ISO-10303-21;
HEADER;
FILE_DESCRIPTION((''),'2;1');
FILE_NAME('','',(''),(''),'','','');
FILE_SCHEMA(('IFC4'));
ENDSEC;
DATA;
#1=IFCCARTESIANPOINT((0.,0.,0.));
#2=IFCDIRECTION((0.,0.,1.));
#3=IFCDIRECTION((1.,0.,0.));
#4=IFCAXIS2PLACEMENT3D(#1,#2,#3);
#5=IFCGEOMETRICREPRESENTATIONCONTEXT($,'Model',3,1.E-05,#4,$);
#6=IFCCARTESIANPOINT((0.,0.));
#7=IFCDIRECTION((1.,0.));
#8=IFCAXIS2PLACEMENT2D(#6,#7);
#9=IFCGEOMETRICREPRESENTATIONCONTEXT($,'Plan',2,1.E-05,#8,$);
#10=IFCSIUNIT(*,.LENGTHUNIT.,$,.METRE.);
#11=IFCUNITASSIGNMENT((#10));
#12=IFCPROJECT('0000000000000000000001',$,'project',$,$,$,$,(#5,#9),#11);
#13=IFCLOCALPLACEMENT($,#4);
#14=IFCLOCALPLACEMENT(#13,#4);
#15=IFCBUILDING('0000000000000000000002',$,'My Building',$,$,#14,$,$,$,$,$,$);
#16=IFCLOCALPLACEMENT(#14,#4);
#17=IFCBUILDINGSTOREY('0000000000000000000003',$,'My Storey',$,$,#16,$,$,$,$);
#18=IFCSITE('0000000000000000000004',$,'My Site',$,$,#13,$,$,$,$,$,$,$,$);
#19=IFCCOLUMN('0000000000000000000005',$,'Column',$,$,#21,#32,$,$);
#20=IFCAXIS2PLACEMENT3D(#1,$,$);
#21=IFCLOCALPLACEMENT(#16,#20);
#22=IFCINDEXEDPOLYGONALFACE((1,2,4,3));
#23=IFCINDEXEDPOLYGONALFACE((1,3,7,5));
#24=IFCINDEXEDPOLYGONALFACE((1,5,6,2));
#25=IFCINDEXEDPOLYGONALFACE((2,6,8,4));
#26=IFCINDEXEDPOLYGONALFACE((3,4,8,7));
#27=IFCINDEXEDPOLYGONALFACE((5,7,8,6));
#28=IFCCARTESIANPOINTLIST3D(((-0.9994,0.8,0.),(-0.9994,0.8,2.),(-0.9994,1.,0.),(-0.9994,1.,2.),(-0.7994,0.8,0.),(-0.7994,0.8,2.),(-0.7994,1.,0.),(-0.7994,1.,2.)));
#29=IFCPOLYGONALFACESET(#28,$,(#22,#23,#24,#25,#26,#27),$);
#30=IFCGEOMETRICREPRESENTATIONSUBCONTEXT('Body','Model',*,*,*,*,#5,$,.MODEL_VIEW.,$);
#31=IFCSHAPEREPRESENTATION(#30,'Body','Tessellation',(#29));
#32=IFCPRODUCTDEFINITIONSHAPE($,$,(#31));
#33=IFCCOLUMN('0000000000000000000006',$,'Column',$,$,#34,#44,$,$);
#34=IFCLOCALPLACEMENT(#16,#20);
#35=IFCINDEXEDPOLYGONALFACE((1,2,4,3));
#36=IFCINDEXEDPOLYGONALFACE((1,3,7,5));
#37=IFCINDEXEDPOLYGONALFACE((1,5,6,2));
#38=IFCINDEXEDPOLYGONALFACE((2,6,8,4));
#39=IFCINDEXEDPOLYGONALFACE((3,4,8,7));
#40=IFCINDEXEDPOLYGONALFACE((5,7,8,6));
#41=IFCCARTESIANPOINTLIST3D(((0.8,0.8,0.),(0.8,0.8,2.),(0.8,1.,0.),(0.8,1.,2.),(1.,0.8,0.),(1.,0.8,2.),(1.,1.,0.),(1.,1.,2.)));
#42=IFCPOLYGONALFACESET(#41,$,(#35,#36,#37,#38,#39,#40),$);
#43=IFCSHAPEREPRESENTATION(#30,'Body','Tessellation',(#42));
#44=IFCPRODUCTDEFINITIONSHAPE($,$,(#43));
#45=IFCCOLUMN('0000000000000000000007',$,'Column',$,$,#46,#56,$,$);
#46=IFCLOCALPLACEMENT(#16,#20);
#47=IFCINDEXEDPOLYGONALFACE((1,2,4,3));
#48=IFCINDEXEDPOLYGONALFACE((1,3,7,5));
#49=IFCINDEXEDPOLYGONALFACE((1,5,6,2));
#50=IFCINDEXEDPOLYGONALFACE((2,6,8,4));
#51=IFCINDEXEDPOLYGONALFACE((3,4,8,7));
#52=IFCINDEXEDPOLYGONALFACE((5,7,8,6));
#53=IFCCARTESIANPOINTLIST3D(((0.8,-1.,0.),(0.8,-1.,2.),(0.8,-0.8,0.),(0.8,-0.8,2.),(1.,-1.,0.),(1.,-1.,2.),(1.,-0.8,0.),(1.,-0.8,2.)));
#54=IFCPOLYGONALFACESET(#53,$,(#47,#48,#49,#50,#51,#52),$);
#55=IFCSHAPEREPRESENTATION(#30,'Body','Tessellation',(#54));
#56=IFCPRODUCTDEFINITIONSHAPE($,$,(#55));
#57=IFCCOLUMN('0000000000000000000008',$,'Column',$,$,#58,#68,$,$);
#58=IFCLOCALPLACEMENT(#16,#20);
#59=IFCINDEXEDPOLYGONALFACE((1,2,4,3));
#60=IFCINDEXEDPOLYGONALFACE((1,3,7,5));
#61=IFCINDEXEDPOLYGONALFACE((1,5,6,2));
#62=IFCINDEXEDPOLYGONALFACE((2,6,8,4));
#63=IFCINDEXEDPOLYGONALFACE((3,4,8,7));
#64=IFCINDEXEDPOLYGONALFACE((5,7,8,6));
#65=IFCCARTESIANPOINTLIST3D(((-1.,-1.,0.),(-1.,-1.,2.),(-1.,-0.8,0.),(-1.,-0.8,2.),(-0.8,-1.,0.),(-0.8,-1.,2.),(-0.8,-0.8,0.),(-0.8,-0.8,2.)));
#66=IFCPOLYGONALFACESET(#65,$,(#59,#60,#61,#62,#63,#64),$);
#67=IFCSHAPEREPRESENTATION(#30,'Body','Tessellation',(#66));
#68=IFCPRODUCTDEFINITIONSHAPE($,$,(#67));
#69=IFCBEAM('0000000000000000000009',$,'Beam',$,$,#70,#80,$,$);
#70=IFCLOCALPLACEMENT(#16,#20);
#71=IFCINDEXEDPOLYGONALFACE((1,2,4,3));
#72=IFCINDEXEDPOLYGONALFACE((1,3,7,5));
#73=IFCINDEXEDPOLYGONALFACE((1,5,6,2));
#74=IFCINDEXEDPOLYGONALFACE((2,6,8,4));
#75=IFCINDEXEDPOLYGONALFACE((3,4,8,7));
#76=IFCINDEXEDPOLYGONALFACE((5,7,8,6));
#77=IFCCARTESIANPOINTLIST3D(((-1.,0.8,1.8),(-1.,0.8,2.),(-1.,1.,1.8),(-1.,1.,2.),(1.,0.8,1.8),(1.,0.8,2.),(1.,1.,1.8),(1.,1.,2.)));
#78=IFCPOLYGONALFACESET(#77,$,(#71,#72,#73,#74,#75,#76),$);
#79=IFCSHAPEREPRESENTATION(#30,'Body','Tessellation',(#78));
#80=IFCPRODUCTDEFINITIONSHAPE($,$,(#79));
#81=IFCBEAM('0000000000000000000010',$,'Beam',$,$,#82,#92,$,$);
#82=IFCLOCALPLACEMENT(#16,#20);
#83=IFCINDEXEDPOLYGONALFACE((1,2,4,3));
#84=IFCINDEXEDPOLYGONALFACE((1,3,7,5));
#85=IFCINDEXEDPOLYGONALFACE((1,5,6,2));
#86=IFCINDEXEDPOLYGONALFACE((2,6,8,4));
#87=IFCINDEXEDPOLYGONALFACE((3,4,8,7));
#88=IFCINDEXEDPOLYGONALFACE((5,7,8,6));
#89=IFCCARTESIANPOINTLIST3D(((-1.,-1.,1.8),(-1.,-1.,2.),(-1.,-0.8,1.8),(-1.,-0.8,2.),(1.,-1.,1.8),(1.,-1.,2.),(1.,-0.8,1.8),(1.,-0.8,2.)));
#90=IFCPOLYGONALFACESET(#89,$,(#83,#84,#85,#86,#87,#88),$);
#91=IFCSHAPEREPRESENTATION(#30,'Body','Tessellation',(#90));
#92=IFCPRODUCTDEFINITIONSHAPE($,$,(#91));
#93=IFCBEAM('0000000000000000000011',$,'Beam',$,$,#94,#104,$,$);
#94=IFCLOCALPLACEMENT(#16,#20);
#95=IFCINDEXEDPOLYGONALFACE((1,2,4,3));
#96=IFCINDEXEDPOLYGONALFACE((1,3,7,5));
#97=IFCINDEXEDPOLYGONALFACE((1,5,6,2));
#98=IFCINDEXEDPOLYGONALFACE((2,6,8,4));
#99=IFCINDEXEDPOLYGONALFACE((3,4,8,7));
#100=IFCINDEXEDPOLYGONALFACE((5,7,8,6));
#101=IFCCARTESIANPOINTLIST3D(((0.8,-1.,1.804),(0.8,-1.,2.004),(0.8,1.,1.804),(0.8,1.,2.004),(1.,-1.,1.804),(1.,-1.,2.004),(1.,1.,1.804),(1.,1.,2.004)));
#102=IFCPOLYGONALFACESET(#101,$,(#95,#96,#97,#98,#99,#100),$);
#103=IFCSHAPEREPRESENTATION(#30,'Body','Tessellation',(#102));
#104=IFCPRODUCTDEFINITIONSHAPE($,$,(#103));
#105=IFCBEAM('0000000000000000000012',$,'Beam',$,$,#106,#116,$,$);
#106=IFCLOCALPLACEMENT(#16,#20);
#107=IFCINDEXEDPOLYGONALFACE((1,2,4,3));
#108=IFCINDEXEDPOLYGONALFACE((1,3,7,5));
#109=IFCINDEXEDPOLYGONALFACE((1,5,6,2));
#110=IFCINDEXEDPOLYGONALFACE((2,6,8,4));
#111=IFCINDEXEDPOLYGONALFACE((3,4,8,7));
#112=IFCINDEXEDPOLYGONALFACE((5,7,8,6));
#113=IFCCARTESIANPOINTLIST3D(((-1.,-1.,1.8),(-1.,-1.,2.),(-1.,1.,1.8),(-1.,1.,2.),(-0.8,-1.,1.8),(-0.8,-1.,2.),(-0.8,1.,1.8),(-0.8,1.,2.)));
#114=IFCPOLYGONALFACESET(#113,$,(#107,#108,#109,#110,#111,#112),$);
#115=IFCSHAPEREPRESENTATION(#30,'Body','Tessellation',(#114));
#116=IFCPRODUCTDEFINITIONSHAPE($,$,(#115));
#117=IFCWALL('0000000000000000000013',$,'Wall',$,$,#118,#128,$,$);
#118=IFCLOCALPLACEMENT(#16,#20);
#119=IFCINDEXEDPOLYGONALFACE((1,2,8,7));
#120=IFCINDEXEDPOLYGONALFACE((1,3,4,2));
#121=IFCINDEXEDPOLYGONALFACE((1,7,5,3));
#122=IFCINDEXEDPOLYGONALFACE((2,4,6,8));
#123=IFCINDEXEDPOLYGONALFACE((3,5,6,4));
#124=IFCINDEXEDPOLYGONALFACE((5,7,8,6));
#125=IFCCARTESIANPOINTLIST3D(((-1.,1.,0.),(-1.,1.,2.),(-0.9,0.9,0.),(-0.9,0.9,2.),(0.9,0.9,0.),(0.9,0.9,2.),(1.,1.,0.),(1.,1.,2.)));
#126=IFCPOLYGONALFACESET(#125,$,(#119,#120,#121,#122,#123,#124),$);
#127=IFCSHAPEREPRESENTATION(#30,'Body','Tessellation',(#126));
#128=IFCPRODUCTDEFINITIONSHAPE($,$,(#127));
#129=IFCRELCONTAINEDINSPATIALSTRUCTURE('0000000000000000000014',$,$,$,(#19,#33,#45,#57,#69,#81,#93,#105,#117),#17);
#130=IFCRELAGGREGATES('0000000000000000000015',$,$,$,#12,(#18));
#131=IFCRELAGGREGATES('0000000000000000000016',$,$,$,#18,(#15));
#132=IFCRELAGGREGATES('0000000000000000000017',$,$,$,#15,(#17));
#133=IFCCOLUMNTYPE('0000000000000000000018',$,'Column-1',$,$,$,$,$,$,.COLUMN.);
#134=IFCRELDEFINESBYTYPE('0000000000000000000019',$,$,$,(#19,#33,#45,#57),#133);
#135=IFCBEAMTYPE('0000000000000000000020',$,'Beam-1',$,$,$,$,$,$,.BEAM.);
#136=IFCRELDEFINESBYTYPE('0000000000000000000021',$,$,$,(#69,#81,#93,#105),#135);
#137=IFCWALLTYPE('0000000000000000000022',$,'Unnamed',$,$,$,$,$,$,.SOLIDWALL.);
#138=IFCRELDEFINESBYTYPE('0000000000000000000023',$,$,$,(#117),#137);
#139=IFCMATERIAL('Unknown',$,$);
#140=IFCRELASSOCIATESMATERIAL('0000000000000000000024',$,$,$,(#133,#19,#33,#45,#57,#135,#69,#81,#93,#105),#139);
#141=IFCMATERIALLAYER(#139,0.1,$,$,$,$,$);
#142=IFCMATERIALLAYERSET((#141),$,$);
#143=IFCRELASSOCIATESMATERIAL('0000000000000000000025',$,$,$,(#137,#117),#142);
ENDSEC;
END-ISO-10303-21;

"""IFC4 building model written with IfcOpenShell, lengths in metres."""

from ifc_helpers import new_model, si_unit, frame, origin_with_axes, origin_2d_with_axis, place, context, subcontext, project, spatial, line, indexed_curve, rectangle, outline, extrude, material, layer, layer_set, layer_usage, material_profile, profile_set, profile_usage, type_object, element, save


model = new_model("IFC4")

# Units and contexts
model_context = context("Model", 3, precision=1e-05, world=origin_with_axes())
plan_context = context("Plan", 2, precision=1e-05, world=origin_2d_with_axis())
body_context_1 = subcontext(model_context, "Body", "Model", "MODEL_VIEW")
ifc_project = project(units=[si_unit("LENGTHUNIT", "METRE")], contexts=[model_context, plan_context])

# Site, building, storey
site_placement = place(None, origin_with_axes())
site = spatial("IfcSite", under=ifc_project, at=site_placement, Name="My Site")
building_placement = place(site_placement, origin_with_axes())
building = spatial("IfcBuilding", under=site, at=building_placement, Name="My Building")
storey_placement = place(building_placement, origin_with_axes())
storey = spatial("IfcBuildingStorey", under=building, at=storey_placement, Name="My Storey")

# Columns
ifc_material = material(Name="Unknown")
ifc_material_profile_1 = material_profile(ifc_material, rectangle(XDim=0.2, YDim=0.2))
ifc_profile_set_1 = profile_set([ifc_material_profile_1])
ifc_profile_usage_1 = profile_usage(ifc_profile_set_1, cardinal=4)
column_type = type_object("IfcColumnType", Name="Column-1", PredefinedType="COLUMN", material=ifc_profile_set_1)
column_1_placement = place(storey_placement, frame((-0.7994, 0.9, 0.0), z_axis=(0.0, 0.0, 1.0), x_axis=(1.0, 0.0, 0.0)))
element("IfcColumn", 1, at=column_1_placement, inside=storey, type_object=column_type, material=ifc_profile_usage_1, Name="Column", context=body_context_1, shape_type="SweptSolid", body=[
    extrude(rectangle(XDim=0.2, YDim=0.2), frame((-0.1, 0.0, 0.0), z_axis=(0.0, 0.0, 1.0), x_axis=(1.0, 0.0, 0.0)), (0.0, 0.0, 1.0), 2.0),
])
ifc_profile_usage_2 = profile_usage(ifc_profile_set_1, cardinal=4)
column_2_placement = place(storey_placement, frame((1.0, 0.9, 0.0), z_axis=(0.0, 0.0, 1.0), x_axis=(1.0, 0.0, 0.0)))
element("IfcColumn", 2, at=column_2_placement, inside=storey, type_object=column_type, material=ifc_profile_usage_2, Name="Column", context=body_context_1, shape_type="SweptSolid", body=[
    extrude(rectangle(XDim=0.2, YDim=0.2), frame((-0.1, 0.0, 0.0), z_axis=(0.0, 0.0, 1.0), x_axis=(1.0, 0.0, 0.0)), (0.0, 0.0, 1.0), 2.0),
])
ifc_profile_usage_3 = profile_usage(ifc_profile_set_1, cardinal=4)
column_3_placement = place(storey_placement, frame((1.0, -0.9, 0.0), z_axis=(0.0, 0.0, 1.0), x_axis=(1.0, 0.0, 0.0)))
element("IfcColumn", 3, at=column_3_placement, inside=storey, type_object=column_type, material=ifc_profile_usage_3, Name="Column", context=body_context_1, shape_type="SweptSolid", body=[
    extrude(rectangle(XDim=0.2, YDim=0.2), frame((-0.1, 0.0, 0.0), z_axis=(0.0, 0.0, 1.0), x_axis=(1.0, 0.0, 0.0)), (0.0, 0.0, 1.0), 2.0),
])
ifc_profile_usage_4 = profile_usage(ifc_profile_set_1, cardinal=4)
column_4_placement = place(storey_placement, frame((-0.8, -0.9, 0.0), z_axis=(0.0, 0.0, 1.0), x_axis=(1.0, 0.0, 0.0)))
element("IfcColumn", 4, at=column_4_placement, inside=storey, type_object=column_type, material=ifc_profile_usage_4, Name="Column", context=body_context_1, shape_type="SweptSolid", body=[
    extrude(rectangle(XDim=0.2, YDim=0.2), frame((-0.1, 0.0, 0.0), z_axis=(0.0, 0.0, 1.0), x_axis=(1.0, 0.0, 0.0)), (0.0, 0.0, 1.0), 2.0),
])

# Beams
ifc_material_profile_2 = material_profile(ifc_material, rectangle(XDim=0.2, YDim=0.2))
ifc_profile_set_2 = profile_set([ifc_material_profile_2])
ifc_profile_usage_5 = profile_usage(ifc_profile_set_2, cardinal=4)
beam_type = type_object("IfcBeamType", Name="Beam-1", PredefinedType="BEAM", material=ifc_profile_set_2)
beam_1_placement = place(storey_placement, frame((1.0, 0.8, 1.9), z_axis=(-1.0, 0.0, 0.0), x_axis=(0.0, -1.0, 0.0)))
element("IfcBeam", 5, at=beam_1_placement, inside=storey, type_object=beam_type, material=ifc_profile_usage_5, Name="Beam", context=body_context_1, shape_type="SweptSolid", body=[
    extrude(rectangle(XDim=0.2, YDim=0.2), frame((-0.1, 0.0, 0.0), z_axis=(0.0, 0.0, 1.0), x_axis=(1.0, 0.0, 0.0)), (0.0, 0.0, 1.0), 2.0),
])
ifc_profile_usage_6 = profile_usage(ifc_profile_set_2, cardinal=4)
beam_2_placement = place(storey_placement, frame((1.0, -1.0, 1.9), z_axis=(-1.0, 0.0, 0.0), x_axis=(0.0, -1.0, 0.0)))
element("IfcBeam", 6, at=beam_2_placement, inside=storey, type_object=beam_type, material=ifc_profile_usage_6, Name="Beam", context=body_context_1, shape_type="SweptSolid", body=[
    extrude(rectangle(XDim=0.2, YDim=0.2), frame((-0.1, 0.0, 0.0), z_axis=(0.0, 0.0, 1.0), x_axis=(1.0, 0.0, 0.0)), (0.0, 0.0, 1.0), 2.0),
])
ifc_profile_usage_7 = profile_usage(ifc_profile_set_2, cardinal=4)
beam_3_placement = place(storey_placement, frame((0.8, -1.0, 1.904), z_axis=(0.0, 1.0, 0.0), x_axis=(-1.0, 0.0, 0.0)))
element("IfcBeam", 7, at=beam_3_placement, inside=storey, type_object=beam_type, material=ifc_profile_usage_7, Name="Beam", context=body_context_1, shape_type="SweptSolid", body=[
    extrude(rectangle(XDim=0.2, YDim=0.2), frame((-0.1, 0.0, 0.0), z_axis=(0.0, 0.0, 1.0), x_axis=(1.0, 0.0, 0.0)), (0.0, 0.0, 1.0), 2.0),
])
ifc_profile_usage_8 = profile_usage(ifc_profile_set_2, cardinal=4)
beam_4_placement = place(storey_placement, frame((-1.0, -1.0, 1.9), z_axis=(0.0, 1.0, 0.0), x_axis=(-1.0, 0.0, 0.0)))
element("IfcBeam", 8, at=beam_4_placement, inside=storey, type_object=beam_type, material=ifc_profile_usage_8, Name="Beam", context=body_context_1, shape_type="SweptSolid", body=[
    extrude(rectangle(XDim=0.2, YDim=0.2), frame((-0.1, 0.0, 0.0), z_axis=(0.0, 0.0, 1.0), x_axis=(1.0, 0.0, 0.0)), (0.0, 0.0, 1.0), 2.0),
])

# Wall
ifc_layer = layer(ifc_material, 0.1)
ifc_layer_set = layer_set([ifc_layer])
ifc_layer_usage_1 = layer_usage(ifc_layer_set, "AXIS2", "POSITIVE", 0.0)
wall_type = type_object("IfcWallType", Name="Unnamed", PredefinedType="SOLIDWALL", material=ifc_layer_set)
wall_1_placement = place(storey_placement, frame((-0.9, 0.9, 0.0), z_axis=(0.0, 0.0, 1.0), x_axis=(1.0, 0.0, 0.0)))
element("IfcWall", 9, at=wall_1_placement, inside=storey, type_object=wall_type, material=ifc_layer_usage_1, Name="Wall", context=body_context_1, shape_type="SweptSolid", body=[
    extrude(outline(indexed_curve([(0.0, 0.0), (-0.1, 0.1), (1.9, 0.1), (1.8, 0.0)], segments=[line(1, 2, 3, 4, 1)])), origin_with_axes(), (0.0, 0.0, 1.0), 2.0),
])

save(model, "model.ifc")
